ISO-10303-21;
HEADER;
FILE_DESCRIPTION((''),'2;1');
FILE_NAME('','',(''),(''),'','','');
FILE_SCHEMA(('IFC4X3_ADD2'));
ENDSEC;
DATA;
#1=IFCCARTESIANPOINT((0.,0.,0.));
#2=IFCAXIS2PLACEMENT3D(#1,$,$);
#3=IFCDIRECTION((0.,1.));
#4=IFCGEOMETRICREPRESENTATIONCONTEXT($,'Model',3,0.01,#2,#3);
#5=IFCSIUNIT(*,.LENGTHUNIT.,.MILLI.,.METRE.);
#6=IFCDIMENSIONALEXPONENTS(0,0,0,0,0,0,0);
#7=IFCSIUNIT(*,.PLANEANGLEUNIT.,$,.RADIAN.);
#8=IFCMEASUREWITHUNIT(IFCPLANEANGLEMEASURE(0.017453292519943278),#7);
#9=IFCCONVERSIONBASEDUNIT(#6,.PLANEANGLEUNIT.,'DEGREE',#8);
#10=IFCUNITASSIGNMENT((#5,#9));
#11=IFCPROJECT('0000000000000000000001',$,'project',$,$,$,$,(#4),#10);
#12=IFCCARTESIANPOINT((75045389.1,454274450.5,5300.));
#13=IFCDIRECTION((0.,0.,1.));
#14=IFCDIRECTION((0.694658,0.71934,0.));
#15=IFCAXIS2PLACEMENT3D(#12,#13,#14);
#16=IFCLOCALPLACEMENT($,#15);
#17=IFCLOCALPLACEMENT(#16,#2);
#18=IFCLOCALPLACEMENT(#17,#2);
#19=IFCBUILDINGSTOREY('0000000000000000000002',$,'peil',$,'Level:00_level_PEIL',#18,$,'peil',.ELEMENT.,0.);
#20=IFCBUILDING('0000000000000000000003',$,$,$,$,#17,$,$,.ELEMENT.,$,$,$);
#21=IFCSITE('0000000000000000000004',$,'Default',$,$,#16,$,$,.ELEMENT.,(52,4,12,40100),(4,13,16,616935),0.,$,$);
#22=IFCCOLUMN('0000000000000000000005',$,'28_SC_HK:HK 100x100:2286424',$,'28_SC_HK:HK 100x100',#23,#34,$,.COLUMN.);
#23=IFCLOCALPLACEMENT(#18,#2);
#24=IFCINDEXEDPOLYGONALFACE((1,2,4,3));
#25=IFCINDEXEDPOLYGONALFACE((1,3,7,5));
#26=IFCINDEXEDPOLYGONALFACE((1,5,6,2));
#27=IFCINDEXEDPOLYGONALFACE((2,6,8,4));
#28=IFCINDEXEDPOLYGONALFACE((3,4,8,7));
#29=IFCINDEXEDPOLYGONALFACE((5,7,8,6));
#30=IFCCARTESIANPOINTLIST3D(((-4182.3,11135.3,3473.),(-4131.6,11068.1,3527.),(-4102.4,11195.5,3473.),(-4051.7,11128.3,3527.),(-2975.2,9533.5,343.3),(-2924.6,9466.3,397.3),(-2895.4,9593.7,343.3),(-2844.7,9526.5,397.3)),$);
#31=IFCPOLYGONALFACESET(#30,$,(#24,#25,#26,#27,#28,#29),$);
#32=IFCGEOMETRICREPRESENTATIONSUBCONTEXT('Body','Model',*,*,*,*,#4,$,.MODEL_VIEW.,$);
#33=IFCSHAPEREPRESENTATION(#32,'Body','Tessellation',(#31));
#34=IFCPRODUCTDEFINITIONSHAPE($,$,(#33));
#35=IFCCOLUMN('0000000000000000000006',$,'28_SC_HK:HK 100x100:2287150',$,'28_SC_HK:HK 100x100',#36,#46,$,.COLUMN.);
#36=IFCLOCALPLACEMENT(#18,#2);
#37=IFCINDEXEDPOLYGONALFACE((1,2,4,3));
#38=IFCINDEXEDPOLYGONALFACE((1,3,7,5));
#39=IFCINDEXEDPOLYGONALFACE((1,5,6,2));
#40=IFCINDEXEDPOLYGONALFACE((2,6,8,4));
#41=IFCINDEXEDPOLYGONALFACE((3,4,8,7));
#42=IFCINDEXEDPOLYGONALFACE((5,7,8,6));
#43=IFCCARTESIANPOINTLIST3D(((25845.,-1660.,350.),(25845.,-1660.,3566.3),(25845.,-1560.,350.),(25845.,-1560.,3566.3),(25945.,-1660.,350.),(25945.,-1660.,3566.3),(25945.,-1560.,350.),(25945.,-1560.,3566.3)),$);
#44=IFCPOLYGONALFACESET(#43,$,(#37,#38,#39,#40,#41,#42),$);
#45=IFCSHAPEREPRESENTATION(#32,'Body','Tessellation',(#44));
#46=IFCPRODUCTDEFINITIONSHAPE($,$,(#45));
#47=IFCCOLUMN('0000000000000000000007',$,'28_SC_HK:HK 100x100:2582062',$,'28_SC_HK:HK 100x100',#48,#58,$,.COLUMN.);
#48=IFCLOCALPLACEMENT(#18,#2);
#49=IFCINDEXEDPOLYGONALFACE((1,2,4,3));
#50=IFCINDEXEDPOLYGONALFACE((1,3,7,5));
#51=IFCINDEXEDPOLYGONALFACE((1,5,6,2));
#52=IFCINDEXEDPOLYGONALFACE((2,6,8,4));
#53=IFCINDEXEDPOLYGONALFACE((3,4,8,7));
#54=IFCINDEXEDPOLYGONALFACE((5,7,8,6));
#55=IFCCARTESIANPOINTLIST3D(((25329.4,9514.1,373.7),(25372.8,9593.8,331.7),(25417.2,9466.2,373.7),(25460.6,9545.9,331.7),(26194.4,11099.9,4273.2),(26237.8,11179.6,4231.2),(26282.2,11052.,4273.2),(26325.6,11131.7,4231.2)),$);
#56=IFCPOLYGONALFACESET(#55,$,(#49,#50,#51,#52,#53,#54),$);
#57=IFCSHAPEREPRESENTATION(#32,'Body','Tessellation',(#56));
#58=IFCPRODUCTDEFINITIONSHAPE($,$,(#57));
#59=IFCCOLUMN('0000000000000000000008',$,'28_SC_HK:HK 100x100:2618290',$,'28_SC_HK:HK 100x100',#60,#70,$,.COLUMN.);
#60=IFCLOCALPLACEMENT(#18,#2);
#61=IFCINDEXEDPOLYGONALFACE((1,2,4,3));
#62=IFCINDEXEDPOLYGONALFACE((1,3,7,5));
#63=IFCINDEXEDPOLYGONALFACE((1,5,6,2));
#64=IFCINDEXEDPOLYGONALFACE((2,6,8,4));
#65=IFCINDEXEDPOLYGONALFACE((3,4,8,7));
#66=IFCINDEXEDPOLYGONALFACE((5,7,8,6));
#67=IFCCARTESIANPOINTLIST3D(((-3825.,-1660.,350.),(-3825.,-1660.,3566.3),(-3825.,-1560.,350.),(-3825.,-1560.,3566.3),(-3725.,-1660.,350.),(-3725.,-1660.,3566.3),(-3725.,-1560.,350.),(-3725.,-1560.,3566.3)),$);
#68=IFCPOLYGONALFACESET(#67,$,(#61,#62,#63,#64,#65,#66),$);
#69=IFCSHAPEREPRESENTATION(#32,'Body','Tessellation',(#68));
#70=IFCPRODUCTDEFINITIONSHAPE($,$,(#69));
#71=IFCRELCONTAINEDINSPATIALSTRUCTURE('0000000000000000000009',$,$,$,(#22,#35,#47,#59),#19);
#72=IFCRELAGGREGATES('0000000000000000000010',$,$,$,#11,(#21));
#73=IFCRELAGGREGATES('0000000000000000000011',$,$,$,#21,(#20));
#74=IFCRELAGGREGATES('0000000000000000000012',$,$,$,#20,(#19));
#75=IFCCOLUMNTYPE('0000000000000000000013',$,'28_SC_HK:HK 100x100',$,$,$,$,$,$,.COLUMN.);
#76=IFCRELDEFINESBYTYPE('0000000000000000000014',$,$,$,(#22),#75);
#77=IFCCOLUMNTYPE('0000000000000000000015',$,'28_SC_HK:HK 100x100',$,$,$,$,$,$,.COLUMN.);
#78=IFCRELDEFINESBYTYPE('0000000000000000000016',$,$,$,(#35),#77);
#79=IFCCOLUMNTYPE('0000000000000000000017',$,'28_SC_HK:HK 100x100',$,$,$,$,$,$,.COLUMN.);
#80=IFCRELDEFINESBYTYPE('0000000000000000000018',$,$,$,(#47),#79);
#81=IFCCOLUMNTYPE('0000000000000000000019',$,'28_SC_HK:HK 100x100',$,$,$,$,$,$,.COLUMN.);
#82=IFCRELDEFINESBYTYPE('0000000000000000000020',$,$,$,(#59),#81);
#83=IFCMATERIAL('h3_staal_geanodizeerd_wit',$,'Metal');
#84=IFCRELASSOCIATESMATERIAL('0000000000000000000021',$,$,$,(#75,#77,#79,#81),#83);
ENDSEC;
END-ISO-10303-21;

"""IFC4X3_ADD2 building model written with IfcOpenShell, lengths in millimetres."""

from ifc_helpers import new_model, entity, si_unit, converted_unit, direction, frame, frame_2d, origin, origin_2d_with_axis, place, context, subcontext, project, spatial, rectangle, extrude, source, transform, mapped, material, material_profile, profile_set, type_object, type_shapes, element, save


model = new_model("IFC4X3_ADD2")

# Units and contexts
model_context = context("Model", 3, precision=0.01, world=origin(), true_north=direction((0.0, 1.0)))
body_context = subcontext(model_context, "Body", "Model", "MODEL_VIEW")
ifc_project = project(units=[si_unit("LENGTHUNIT", "METRE", prefix="MILLI"), converted_unit("PLANEANGLEUNIT", "DEGREE", entity("IfcPlaneAngleMeasure", 0.017453292519943278), si_unit("PLANEANGLEUNIT", "RADIAN"), dimensions=[0, 0, 0, 0, 0, 0, 0])], contexts=[model_context])

# Site, building, storey
site_placement = place(None, frame((75045389.1, 454274450.5, 5300.0), z_axis=(0.0, 0.0, 1.0), x_axis=(0.694658, 0.71934, 0.0)))
site = spatial("IfcSite", under=ifc_project, at=site_placement, Name="Default", CompositionType="ELEMENT", RefLatitude=(52, 4, 12, 40100), RefLongitude=(4, 13, 16, 616935), RefElevation=0.0)
building_placement = place(site_placement, origin())
building = spatial("IfcBuilding", under=site, at=building_placement, CompositionType="ELEMENT")
storey_placement = place(building_placement, origin())
storey = spatial("IfcBuildingStorey", under=building, at=storey_placement, Name="peil", ObjectType="Level:00_level_PEIL", LongName="peil", CompositionType="ELEMENT", Elevation=0.0)

# Columns
ifc_material = material(Name="h3_staal_geanodizeerd_wit", Category="Metal")
ifc_material_profile = material_profile(ifc_material, rectangle(XDim=100.0, YDim=100.0, at=frame_2d((0.0, 0.0), x_axis=(1.0, 0.0))), Name="HK 100x100")
ifc_profile_set = profile_set([ifc_material_profile], Name="HK 100x100")
column_type_1 = type_object("IfcColumnType", Name="28_SC_HK:HK 100x100", PredefinedType="COLUMN", material=ifc_profile_set)
shared_shape_1 = source(origin(), body_context, "Body", "SweptSolid", [
    extrude(rectangle(XDim=100.0, YDim=100.0, at=frame_2d((0.0, 0.0), x_axis=(1.0, 0.0))), frame((-2910.0, 9530.0, 370.3), z_axis=(-0.324714, 0.430911, 0.841948), x_axis=(-0.506697, 0.67241, -0.539559)), (0.0, 0.0, 1.0), 3717.2),
])
type_shapes(column_type_1, [shared_shape_1])
column_1_placement = place(storey_placement, origin())
element("IfcColumn", 1, at=column_1_placement, inside=storey, type_object=column_type_1, Name="28_SC_HK:HK 100x100:2286424", ObjectType="28_SC_HK:HK 100x100", PredefinedType="COLUMN", context=body_context, shape_type="MappedRepresentation", body=[
    mapped(shared_shape_1, transform((0.0, 0.0, 0.0), scale=1.0)),
])
column_type_2 = type_object("IfcColumnType", Name="28_SC_HK:HK 100x100", PredefinedType="COLUMN", material=ifc_profile_set)
shared_shape_2 = source(origin(), body_context, "Body", "SweptSolid", [
    extrude(rectangle(XDim=100.0, YDim=100.0, at=frame_2d((0.0, 0.0), x_axis=(1.0, 0.0))), frame((25895.0, -1610.0, 350.0), z_axis=(0.0, 0.0, 1.0), x_axis=(-1.0, 0.0, 0.0)), (0.0, 0.0, 1.0), 3216.3),
])
type_shapes(column_type_2, [shared_shape_2])
column_2_placement = place(storey_placement, origin())
element("IfcColumn", 2, at=column_2_placement, inside=storey, type_object=column_type_2, Name="28_SC_HK:HK 100x100:2287150", ObjectType="28_SC_HK:HK 100x100", PredefinedType="COLUMN", context=body_context, shape_type="MappedRepresentation", body=[
    mapped(shared_shape_2, transform((0.0, 0.0, 0.0), scale=1.0)),
])
column_type_3 = type_object("IfcColumnType", Name="28_SC_HK:HK 100x100", PredefinedType="COLUMN", material=ifc_profile_set)
shared_shape_3 = source(origin(), body_context, "Body", "SweptSolid", [
    extrude(rectangle(XDim=100.0, YDim=100.0, at=frame_2d((0.0, 0.0), x_axis=(0.0, 1.0))), frame((25395.0, 9530.0, 352.7), z_axis=(0.201272, 0.368998, 0.907376), x_axis=(-0.877896, 0.478852, 0.0)), (0.0, 0.0, 1.0), 4297.6),
])
type_shapes(column_type_3, [shared_shape_3])
column_3_placement = place(storey_placement, origin())
element("IfcColumn", 3, at=column_3_placement, inside=storey, type_object=column_type_3, Name="28_SC_HK:HK 100x100:2582062", ObjectType="28_SC_HK:HK 100x100", PredefinedType="COLUMN", context=body_context, shape_type="MappedRepresentation", body=[
    mapped(shared_shape_3, transform((0.0, 0.0, 0.0), scale=1.0)),
])
column_type_4 = type_object("IfcColumnType", Name="28_SC_HK:HK 100x100", PredefinedType="COLUMN", material=ifc_profile_set)
shared_shape_4 = source(origin(), body_context, "Body", "SweptSolid", [
    extrude(rectangle(XDim=100.0, YDim=100.0, at=origin_2d_with_axis()), frame((-3775.0, -1610.0, 350.0), z_axis=(0.0, 0.0, 1.0), x_axis=(-1.0, 0.0, 0.0)), (0.0, 0.0, 1.0), 3216.3),
])
type_shapes(column_type_4, [shared_shape_4])
column_4_placement = place(storey_placement, origin())
element("IfcColumn", 4, at=column_4_placement, inside=storey, type_object=column_type_4, Name="28_SC_HK:HK 100x100:2618290", ObjectType="28_SC_HK:HK 100x100", PredefinedType="COLUMN", context=body_context, shape_type="MappedRepresentation", body=[
    mapped(shared_shape_4, transform((0.0, 0.0, 0.0), scale=1.0)),
])

save(model, "model.ifc")
